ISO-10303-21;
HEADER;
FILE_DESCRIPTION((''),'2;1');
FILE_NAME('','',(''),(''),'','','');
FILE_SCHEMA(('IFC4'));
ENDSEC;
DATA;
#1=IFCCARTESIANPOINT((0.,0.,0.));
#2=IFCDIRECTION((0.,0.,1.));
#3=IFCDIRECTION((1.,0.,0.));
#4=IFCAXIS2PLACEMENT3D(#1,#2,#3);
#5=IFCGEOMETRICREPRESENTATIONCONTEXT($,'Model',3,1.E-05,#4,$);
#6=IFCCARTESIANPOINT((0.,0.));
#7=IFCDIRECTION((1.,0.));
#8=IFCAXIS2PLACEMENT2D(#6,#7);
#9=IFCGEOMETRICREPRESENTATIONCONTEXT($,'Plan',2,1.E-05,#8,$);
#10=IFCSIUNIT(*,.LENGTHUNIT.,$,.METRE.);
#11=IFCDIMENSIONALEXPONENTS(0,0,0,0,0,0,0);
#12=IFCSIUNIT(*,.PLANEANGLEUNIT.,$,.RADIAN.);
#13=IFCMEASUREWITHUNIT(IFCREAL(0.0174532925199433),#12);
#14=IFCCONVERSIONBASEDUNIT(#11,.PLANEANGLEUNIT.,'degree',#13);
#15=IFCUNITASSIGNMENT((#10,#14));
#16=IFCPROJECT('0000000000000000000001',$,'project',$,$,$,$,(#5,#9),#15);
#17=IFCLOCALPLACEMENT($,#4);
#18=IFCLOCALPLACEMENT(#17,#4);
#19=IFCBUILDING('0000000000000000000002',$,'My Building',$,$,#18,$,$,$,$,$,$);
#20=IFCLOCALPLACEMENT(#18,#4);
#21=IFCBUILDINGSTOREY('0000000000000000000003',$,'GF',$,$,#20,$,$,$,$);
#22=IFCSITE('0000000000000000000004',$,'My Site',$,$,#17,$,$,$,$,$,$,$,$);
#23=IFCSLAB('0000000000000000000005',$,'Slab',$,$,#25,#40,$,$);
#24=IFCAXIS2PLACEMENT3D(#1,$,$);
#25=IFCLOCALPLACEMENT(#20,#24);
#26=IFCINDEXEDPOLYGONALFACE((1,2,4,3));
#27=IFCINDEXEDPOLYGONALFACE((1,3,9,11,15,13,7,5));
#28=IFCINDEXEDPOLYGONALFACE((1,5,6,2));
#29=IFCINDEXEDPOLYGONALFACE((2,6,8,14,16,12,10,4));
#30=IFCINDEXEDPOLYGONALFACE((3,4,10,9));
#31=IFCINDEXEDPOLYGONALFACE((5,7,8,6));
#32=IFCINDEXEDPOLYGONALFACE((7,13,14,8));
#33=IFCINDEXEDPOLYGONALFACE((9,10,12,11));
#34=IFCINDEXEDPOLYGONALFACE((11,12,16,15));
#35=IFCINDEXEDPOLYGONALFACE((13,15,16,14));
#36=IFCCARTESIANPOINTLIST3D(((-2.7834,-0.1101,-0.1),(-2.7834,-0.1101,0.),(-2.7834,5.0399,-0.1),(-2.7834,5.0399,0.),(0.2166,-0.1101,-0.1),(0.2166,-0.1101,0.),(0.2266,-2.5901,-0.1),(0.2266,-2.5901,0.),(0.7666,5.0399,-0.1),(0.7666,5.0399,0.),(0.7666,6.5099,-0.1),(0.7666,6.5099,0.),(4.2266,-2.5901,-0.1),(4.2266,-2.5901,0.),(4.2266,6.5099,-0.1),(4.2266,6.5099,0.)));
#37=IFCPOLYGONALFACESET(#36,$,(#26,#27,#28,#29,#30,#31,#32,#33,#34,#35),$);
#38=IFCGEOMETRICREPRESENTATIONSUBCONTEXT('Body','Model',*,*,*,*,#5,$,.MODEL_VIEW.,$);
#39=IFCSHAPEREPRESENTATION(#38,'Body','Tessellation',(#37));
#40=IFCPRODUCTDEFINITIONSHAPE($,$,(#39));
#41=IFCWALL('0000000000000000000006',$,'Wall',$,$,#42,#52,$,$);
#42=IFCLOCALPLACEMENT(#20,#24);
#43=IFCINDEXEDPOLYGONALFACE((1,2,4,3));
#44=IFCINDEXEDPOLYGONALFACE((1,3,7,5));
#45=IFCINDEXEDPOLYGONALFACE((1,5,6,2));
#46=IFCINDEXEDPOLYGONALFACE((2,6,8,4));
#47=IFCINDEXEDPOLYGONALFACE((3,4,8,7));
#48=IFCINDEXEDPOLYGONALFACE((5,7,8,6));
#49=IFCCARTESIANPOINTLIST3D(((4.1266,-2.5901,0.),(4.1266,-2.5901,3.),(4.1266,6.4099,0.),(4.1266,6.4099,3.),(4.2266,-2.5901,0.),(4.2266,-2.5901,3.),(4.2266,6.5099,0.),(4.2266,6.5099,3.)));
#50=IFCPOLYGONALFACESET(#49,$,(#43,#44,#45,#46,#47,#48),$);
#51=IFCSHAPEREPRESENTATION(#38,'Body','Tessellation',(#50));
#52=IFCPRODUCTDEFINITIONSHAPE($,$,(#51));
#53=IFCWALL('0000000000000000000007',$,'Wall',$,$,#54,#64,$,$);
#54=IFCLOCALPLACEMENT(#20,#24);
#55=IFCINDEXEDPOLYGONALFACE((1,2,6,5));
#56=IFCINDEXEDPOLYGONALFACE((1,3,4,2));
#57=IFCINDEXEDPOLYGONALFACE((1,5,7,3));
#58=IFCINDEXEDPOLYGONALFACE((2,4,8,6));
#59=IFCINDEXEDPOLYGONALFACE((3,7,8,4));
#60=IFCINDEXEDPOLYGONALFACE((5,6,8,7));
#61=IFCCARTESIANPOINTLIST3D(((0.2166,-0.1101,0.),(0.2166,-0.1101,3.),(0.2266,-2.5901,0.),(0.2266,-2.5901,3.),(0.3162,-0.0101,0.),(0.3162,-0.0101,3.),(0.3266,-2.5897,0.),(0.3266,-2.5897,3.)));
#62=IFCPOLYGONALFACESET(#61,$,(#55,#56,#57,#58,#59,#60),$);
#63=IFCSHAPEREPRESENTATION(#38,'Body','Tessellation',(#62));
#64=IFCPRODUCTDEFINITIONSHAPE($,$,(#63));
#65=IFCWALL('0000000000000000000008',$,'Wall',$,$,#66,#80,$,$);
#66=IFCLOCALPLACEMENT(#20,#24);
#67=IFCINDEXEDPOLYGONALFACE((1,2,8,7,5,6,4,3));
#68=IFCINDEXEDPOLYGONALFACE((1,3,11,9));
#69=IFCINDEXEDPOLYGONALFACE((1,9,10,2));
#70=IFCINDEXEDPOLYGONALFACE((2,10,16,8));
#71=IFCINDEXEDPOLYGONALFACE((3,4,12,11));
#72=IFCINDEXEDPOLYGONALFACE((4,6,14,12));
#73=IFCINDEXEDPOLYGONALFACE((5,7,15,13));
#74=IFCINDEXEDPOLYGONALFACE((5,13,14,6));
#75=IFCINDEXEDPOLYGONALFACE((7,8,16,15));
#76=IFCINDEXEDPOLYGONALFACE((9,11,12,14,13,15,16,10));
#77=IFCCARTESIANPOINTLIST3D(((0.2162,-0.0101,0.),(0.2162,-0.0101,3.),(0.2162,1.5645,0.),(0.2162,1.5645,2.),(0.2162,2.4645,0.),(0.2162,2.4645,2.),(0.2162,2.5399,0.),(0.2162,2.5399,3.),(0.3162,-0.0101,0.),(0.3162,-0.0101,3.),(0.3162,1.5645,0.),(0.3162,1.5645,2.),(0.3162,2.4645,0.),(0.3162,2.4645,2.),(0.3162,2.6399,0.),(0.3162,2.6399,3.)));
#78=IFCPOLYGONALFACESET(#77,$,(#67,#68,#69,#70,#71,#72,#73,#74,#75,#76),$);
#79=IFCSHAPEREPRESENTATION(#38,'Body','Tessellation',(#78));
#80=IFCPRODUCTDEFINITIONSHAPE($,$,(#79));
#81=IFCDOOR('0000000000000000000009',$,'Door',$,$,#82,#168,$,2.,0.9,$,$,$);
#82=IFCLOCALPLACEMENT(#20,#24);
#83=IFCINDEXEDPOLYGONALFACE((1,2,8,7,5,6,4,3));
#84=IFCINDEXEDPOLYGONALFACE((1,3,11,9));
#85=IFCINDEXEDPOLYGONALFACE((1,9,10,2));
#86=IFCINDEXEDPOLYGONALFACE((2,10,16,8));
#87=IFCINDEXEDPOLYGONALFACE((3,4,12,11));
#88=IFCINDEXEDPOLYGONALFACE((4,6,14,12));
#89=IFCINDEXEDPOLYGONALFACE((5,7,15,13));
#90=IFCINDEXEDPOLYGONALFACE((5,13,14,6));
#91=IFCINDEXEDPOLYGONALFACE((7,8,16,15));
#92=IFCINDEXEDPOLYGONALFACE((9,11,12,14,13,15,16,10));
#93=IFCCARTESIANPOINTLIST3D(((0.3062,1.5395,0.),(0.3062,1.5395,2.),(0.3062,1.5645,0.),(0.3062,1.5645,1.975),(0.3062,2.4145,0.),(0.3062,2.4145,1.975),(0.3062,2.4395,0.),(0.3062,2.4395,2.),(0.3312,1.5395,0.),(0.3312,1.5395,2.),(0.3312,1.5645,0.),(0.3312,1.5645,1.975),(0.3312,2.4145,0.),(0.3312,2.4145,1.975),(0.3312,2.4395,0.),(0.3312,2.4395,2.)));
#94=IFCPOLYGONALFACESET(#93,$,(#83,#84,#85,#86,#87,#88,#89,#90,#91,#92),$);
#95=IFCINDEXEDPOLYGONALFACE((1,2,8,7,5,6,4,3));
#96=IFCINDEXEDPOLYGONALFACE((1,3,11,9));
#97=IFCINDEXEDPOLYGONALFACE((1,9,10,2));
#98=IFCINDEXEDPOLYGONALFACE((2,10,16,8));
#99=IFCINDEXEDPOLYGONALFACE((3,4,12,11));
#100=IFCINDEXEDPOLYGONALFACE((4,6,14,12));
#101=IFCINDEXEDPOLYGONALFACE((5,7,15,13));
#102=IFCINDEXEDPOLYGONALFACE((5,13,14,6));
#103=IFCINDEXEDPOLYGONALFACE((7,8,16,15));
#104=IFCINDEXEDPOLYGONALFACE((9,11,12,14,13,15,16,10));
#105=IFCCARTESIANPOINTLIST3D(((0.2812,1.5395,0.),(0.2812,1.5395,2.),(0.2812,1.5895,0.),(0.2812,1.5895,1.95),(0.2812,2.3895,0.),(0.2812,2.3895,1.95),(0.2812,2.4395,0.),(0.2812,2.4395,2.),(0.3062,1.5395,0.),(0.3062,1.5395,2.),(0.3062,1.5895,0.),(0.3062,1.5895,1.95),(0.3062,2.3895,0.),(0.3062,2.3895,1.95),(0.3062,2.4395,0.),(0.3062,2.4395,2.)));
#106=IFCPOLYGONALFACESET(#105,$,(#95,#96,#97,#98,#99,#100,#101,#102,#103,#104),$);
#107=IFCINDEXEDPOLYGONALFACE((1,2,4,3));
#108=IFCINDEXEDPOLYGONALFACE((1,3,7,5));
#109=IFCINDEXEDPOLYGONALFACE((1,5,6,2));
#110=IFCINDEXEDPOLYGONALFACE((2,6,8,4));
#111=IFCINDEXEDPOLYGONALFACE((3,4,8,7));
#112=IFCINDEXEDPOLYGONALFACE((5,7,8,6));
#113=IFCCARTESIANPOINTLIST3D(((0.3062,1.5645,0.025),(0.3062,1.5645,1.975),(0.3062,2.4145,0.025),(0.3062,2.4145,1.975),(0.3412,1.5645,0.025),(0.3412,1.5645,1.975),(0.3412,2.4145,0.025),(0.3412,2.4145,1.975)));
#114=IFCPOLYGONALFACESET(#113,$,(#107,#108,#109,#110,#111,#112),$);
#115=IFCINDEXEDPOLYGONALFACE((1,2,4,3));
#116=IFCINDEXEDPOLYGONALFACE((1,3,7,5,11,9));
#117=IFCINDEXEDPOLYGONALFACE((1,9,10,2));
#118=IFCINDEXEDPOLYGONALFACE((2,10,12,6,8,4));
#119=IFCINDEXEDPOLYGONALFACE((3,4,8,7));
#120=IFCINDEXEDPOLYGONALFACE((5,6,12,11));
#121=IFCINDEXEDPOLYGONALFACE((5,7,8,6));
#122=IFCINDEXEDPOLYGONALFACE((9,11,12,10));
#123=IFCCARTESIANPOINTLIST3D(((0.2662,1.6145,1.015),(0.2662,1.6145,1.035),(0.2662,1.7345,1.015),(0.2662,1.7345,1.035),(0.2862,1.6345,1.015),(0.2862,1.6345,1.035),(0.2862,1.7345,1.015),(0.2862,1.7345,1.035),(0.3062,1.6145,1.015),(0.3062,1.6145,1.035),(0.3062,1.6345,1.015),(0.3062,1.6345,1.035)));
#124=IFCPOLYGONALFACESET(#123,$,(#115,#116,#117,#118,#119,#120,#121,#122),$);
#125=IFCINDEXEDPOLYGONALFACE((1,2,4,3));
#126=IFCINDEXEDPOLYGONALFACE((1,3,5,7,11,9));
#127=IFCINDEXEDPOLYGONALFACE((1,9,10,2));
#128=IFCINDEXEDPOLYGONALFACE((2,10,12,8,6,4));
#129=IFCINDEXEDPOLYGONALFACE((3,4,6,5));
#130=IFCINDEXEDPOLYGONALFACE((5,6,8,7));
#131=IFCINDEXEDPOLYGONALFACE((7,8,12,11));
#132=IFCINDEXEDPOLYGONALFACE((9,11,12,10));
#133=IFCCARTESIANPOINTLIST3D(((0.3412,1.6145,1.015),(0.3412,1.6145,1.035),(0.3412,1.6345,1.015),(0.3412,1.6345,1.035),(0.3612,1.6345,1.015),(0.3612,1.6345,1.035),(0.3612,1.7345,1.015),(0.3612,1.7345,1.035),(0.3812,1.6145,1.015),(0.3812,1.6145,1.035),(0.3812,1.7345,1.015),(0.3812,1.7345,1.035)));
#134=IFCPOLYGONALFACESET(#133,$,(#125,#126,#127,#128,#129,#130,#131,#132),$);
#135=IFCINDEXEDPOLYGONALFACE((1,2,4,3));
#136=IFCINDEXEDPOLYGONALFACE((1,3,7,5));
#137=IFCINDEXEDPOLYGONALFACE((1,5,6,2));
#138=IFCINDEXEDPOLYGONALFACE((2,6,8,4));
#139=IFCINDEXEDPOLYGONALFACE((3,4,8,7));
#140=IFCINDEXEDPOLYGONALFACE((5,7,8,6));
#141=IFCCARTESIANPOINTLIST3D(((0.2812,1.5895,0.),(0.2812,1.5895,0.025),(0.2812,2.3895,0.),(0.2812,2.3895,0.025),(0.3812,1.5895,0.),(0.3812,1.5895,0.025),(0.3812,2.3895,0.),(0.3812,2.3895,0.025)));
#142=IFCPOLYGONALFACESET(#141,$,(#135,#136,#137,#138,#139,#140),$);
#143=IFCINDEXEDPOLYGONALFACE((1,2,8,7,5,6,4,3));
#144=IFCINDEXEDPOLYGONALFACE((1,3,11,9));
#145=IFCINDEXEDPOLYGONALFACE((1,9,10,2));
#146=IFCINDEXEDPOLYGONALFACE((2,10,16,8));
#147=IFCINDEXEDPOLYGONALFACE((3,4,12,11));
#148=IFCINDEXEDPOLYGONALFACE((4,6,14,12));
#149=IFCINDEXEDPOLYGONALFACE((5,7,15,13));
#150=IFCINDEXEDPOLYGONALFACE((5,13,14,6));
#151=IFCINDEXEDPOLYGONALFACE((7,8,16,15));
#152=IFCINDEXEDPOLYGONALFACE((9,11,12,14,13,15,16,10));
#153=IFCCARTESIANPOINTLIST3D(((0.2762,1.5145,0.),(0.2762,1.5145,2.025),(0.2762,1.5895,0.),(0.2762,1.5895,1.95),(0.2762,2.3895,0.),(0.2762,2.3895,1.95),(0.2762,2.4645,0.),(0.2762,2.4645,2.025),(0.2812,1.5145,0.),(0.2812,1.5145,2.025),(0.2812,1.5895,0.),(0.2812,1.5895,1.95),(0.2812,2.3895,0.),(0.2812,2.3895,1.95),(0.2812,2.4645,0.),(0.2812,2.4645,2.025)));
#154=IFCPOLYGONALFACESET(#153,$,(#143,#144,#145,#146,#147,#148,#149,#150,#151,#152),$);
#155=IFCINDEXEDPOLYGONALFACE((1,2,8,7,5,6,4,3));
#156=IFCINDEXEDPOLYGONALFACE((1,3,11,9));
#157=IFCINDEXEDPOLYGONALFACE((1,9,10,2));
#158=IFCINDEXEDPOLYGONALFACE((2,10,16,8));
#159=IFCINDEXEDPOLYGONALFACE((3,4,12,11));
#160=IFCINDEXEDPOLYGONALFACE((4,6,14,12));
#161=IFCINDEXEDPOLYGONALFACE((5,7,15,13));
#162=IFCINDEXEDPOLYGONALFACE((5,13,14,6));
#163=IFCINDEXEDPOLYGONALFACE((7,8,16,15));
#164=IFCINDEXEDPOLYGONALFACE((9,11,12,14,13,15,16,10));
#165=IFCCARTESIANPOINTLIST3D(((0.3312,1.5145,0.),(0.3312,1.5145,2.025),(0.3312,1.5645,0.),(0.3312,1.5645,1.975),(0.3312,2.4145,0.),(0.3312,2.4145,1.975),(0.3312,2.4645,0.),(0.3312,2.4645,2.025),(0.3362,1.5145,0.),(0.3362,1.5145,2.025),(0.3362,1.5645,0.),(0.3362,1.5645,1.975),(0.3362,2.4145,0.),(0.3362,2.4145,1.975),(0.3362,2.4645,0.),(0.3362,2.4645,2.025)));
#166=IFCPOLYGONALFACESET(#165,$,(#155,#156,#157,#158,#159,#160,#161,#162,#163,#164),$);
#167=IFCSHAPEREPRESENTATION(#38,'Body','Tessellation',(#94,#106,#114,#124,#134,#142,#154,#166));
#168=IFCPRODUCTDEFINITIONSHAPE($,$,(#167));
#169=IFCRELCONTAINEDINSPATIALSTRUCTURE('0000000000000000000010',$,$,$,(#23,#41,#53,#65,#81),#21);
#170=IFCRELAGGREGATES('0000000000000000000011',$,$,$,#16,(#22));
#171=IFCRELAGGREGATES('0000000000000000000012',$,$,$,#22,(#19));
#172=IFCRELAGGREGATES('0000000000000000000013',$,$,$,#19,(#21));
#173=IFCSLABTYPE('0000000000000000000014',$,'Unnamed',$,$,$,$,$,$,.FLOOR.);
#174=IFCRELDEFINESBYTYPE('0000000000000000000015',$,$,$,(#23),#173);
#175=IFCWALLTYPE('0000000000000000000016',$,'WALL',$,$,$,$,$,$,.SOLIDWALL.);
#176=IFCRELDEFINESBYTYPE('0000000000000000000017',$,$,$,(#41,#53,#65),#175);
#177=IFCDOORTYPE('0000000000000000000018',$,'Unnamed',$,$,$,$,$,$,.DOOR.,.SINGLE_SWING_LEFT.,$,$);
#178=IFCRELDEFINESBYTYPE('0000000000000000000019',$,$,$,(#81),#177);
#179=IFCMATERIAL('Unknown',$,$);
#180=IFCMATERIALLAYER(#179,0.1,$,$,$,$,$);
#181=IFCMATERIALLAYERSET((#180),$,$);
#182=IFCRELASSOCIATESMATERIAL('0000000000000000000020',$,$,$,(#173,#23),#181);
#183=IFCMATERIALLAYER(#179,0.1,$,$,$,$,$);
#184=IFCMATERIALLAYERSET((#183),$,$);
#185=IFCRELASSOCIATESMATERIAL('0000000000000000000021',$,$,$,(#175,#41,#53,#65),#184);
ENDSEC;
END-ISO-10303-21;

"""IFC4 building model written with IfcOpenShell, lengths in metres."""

from ifc_helpers import new_model, entity, si_unit, converted_unit, frame, origin_with_axes, origin_2d_with_axis, place, context, subcontext, project, spatial, line, indexed_curve, outline, extrude, shape, source, transform, mapped, material, layer, layer_set, layer_usage, type_object, type_shapes, element, fill, save


model = new_model("IFC4")

# Units and contexts
model_context = context("Model", 3, precision=1e-05, world=origin_with_axes())
plan_context = context("Plan", 2, precision=1e-05, world=origin_2d_with_axis())
body_context_1 = subcontext(model_context, "Body", "Model", "MODEL_VIEW")
body_context_2 = subcontext(plan_context, "Body", "Plan", "PLAN_VIEW")
ifc_project = project(units=[si_unit("LENGTHUNIT", "METRE"), converted_unit("PLANEANGLEUNIT", "degree", entity("IfcReal", 0.0174532925199433), si_unit("PLANEANGLEUNIT", "RADIAN"), dimensions=[0, 0, 0, 0, 0, 0, 0])], contexts=[model_context, plan_context])

# Site, building, storey
site_placement = place(None, origin_with_axes())
site = spatial("IfcSite", under=ifc_project, at=site_placement, Name="My Site")
building_placement = place(site_placement, origin_with_axes())
building = spatial("IfcBuilding", under=site, at=building_placement, Name="My Building")
storey_placement = place(building_placement, origin_with_axes())
storey = spatial("IfcBuildingStorey", under=building, at=storey_placement, Name="GF")

# Slab
ifc_material = material(Name="Unknown")
ifc_layer_1 = layer(ifc_material, 0.1)
ifc_layer_set_1 = layer_set([ifc_layer_1])
ifc_layer_usage_1 = layer_usage(ifc_layer_set_1, "AXIS3", "POSITIVE", -0.1)
slab_type_1 = type_object("IfcSlabType", Name="Unnamed", PredefinedType="FLOOR", material=ifc_layer_set_1)
slab_1_placement = place(storey_placement, frame((4.2266, -2.5901, 0.0), z_axis=(0.0, 0.0, 1.0), x_axis=(1.0, 0.0, 0.0)))
element("IfcSlab", 1, at=slab_1_placement, inside=storey, type_object=slab_type_1, material=ifc_layer_usage_1, Name="Slab", context=body_context_1, shape_type="SweptSolid", body=[
    extrude(outline(indexed_curve([(0.0, 0.0), (0.0, 9.1), (-3.46, 9.1), (-3.46, 7.63), (-7.01, 7.63), (-7.01, 2.48), (-4.01, 2.48), (-4.0, 0.0), (0.0, 0.0)])), frame((0.0, 0.0, -0.1), z_axis=(0.0, 0.0, 1.0), x_axis=(1.0, 0.0, 0.0)), (0.0, 0.0, 1.0), 0.1),
])

# Shared definitions
ifc_layer_2 = layer(ifc_material, 0.1)
ifc_layer_set_2 = layer_set([ifc_layer_2])
wall_type = type_object("IfcWallType", Name="WALL", PredefinedType="SOLIDWALL", material=ifc_layer_set_2)
shared_shape_1 = source(origin_with_axes(), body_context_1, "Body", "SweptSolid", [
    extrude(outline(indexed_curve([(0.0, 0.0), (0.9, 0.0), (0.9, 2.0), (0.0, 2.0)], segments=[line(1, 2, 3, 4, 1)])), frame((0.0, -0.6, 0.0), z_axis=(0.0, -1.0, 0.0), x_axis=(1.0, 0.0, 0.0)), (0.0, 0.0, -1.0), 1.2),
])
door_type = type_object("IfcDoorType", Name="Unnamed", OperationType="SINGLE_SWING_LEFT", PredefinedType="DOOR")
shared_shape_2 = source(origin_with_axes(), body_context_1, "Body", "SweptSolid", [
    extrude(outline(indexed_curve([(0.0, 0.0), (0.0, 2.0), (0.9, 2.0), (0.9, 0.0), (0.875, 0.0), (0.875, 1.975), (0.025, 1.975), (0.025, 0.0)], segments=[line(1, 2, 3, 4, 5, 6, 7, 8, 1)])), frame((0.0, 0.025, 0.0), z_axis=(0.0, -1.0, 0.0), x_axis=(1.0, 0.0, 0.0)), (0.0, 0.0, -1.0), 0.025),
    extrude(outline(indexed_curve([(0.0, 0.0), (0.0, 2.0), (0.9, 2.0), (0.9, 0.0), (0.85, 0.0), (0.85, 1.95), (0.05, 1.95), (0.05, 0.0)], segments=[line(1, 2, 3, 4, 5, 6, 7, 8, 1)])), frame((0.0, 0.0, 0.0), z_axis=(0.0, -1.0, 0.0), x_axis=(1.0, 0.0, 0.0)), (0.0, 0.0, -1.0), 0.025),
    extrude(outline(indexed_curve([(0.0, 0.0), (0.85, 0.0), (0.85, 0.035), (0.0, 0.035)], segments=[line(1, 2, 3, 4, 1)])), frame((0.025, 0.025, 0.025), z_axis=(0.0, 0.0, 1.0), x_axis=(1.0, 0.0, 0.0)), (0.0, 0.0, 1.0), 1.95),
    extrude(outline(indexed_curve([(0.0, 0.0), (0.0, -0.04), (-0.12, -0.04), (-0.12, -0.02), (-0.02, -0.02), (-0.02, 0.0)], segments=[line(1, 2, 3, 4, 5, 6, 1)])), frame((0.825, 0.025, 1.015), z_axis=(0.0, 0.0, 1.0), x_axis=(1.0, 0.0, 0.0)), (0.0, 0.0, 1.0), 0.02),
    extrude(outline(indexed_curve([(0.0, 0.0), (0.0, 0.04), (-0.12, 0.04), (-0.12, 0.02), (-0.02, 0.02), (-0.02, 0.0)], segments=[line(1, 2, 3, 4, 5, 6, 1)])), frame((0.825, 0.06, 1.015), z_axis=(0.0, 0.0, 1.0), x_axis=(1.0, 0.0, 0.0)), (0.0, 0.0, 1.0), 0.02),
    extrude(outline(indexed_curve([(0.0, 0.0), (0.8, 0.0), (0.8, 0.1), (0.0, 0.1)], segments=[line(1, 2, 3, 4, 1)])), frame((0.05, 0.0, 0.0), z_axis=(0.0, 0.0, 1.0), x_axis=(1.0, 0.0, 0.0)), (0.0, 0.0, 1.0), 0.025),
    extrude(outline(indexed_curve([(0.0, 0.0), (0.0, 2.025), (0.95, 2.025), (0.95, 0.0), (0.875, 0.0), (0.875, 1.95), (0.075, 1.95), (0.075, 0.0)], segments=[line(1, 2, 3, 4, 5, 6, 7, 8, 1)])), frame((-0.025, -0.005, 0.0), z_axis=(0.0, -1.0, 0.0), x_axis=(1.0, 0.0, 0.0)), (0.0, 0.0, -1.0), 0.005),
    extrude(outline(indexed_curve([(0.0, 0.0), (0.0, 2.025), (0.95, 2.025), (0.95, 0.0), (0.9, 0.0), (0.9, 1.975), (0.05, 1.975), (0.05, 0.0)], segments=[line(1, 2, 3, 4, 5, 6, 7, 8, 1)])), frame((-0.025, 0.05, 0.0), z_axis=(0.0, -1.0, 0.0), x_axis=(1.0, 0.0, 0.0)), (0.0, 0.0, -1.0), 0.005),
])
shared_shape_3 = source(origin_with_axes(), body_context_2, "Body", "Curve2D", [
    entity("IfcIndexedPolyCurve", entity("IfcCartesianPointList2D", [[0.0, 0.0], [0.0, 0.05], [0.025, 0.05], [0.025, 0.025], [0.05, 0.025], [0.05, 0.0]]), [entity("IfcLineIndex", [1, 2, 3, 4, 5, 6, 1])]),
    entity("IfcIndexedPolyCurve", entity("IfcCartesianPointList2D", [[0.9, 0.0], [0.9, 0.05], [0.875, 0.05], [0.875, 0.025], [0.85, 0.025], [0.85, 0.0]]), [entity("IfcLineIndex", [1, 2, 3, 4, 5, 6, 1])]),
    entity("IfcTrimmedCurve", entity("IfcEllipse", entity("IfcAxis2Placement2D", entity("IfcCartesianPoint", [0.06, 0.05]), entity("IfcDirection", [1.0, 0.0])), 0.815, 0.85), [entity("IfcCartesianPoint", [0.875, 0.05])], [entity("IfcCartesianPoint", [0.06, 0.9])], True, "CARTESIAN"),
    entity("IfcIndexedPolyCurve", entity("IfcCartesianPointList2D", [[0.025, 0.05], [0.06, 0.05], [0.06, 0.9], [0.025, 0.9]]), [entity("IfcLineIndex", [1, 2, 3, 4, 1])]),
])
type_shapes(door_type, [shared_shape_2, shared_shape_3])

# Wall
ifc_layer_usage_2 = layer_usage(ifc_layer_set_2, "AXIS2", "POSITIVE", 0.0)
wall_1_placement = place(storey_placement, frame((4.2266, -2.5901, 0.0), z_axis=(0.0, 0.0, 1.0), x_axis=(0.0, 1.0, 0.0)))
element("IfcWall", 2, at=wall_1_placement, inside=storey, type_object=wall_type, material=ifc_layer_usage_2, Name="Wall", context=body_context_1, shape_type="SweptSolid", body=[
    extrude(outline(indexed_curve([(0.0, 0.0), (0.0, 0.1), (9.0, 0.1), (9.1, 0.0)], segments=[line(1, 2, 3, 4, 1)])), origin_with_axes(), (0.0, 0.0, 1.0), 3.0),
])

# Wall
ifc_layer_usage_3 = layer_usage(ifc_layer_set_2, "AXIS2", "POSITIVE", 0.0)
wall_2_placement = place(storey_placement, frame((0.2166, -0.1101, 0.0), z_axis=(0.0, 0.0, 1.0), x_axis=(0.004032, -0.999992, 0.0)))
element("IfcWall", 3, at=wall_2_placement, inside=storey, type_object=wall_type, material=ifc_layer_usage_3, Name="Wall", context=body_context_1, shape_type="SweptSolid", body=[
    extrude(outline(indexed_curve([(0.0, 0.0), (-0.0996, 0.1), (2.48, 0.1), (2.48, 0.0)], segments=[line(1, 2, 3, 4, 1)])), origin_with_axes(), (0.0, 0.0, 1.0), 3.0),
])

# Wall, opening, door
ifc_layer_usage_4 = layer_usage(ifc_layer_set_2, "AXIS2", "POSITIVE", 0.0)
wall_3_placement = place(storey_placement, frame((0.3162, -0.0101, 0.0), z_axis=(0.0, 0.0, 1.0), x_axis=(0.0, 1.0, 0.0)))
wall_3 = element("IfcWall", 4, at=wall_3_placement, inside=storey, type_object=wall_type, material=ifc_layer_usage_4, Name="Wall", context=body_context_1, shape_type="SweptSolid", body=[
    extrude(outline(indexed_curve([(0.0, 0.0), (0.0, 0.1), (2.55, 0.1), (2.65, 0.0)], segments=[line(1, 2, 3, 4, 1)])), origin_with_axes(), (0.0, 0.0, 1.0), 3.0),
])
opening_1_placement = place(wall_3_placement, frame((1.5746, 0.0, 0.0), z_axis=(0.0, 0.0, 1.0), x_axis=(1.0, 0.0, 0.0)))
opening_1 = element("IfcOpeningElement", 5, at=opening_1_placement, cuts=wall_3, PredefinedType="OPENING", context=body_context_1, shape_type="MappedRepresentation", body=[
    mapped(shared_shape_1, transform((0.0, 0.0, 0.0), x_axis=(1.0, 0.0, 0.0), y_axis=(0.0, 1.0, 0.0), z_axis=(0.0, 0.0, 1.0), scale=1.0)),
])
door_1_placement = place(opening_1_placement, frame((0.875, 0.035, 0.0), z_axis=(0.0, 0.0, 1.0), x_axis=(-1.0, 0.0, 0.0)))
door_1 = element("IfcDoor", 6, at=door_1_placement, inside=storey, type_object=door_type, Name="Door", OverallHeight=2.0, OverallWidth=0.9, shapes=[
    shape(body_context_1, "Body", "MappedRepresentation", [mapped(shared_shape_2, transform((0.0, 0.0, 0.0), x_axis=(1.0, 0.0, 0.0), y_axis=(0.0, 1.0, 0.0), z_axis=(0.0, 0.0, 1.0), scale=1.0))]),
    shape(body_context_2, "Body", "MappedRepresentation", [mapped(shared_shape_3, transform((0.0, 0.0, 0.0), x_axis=(1.0, 0.0, 0.0), y_axis=(0.0, 1.0, 0.0), z_axis=(0.0, 0.0, 1.0), scale=1.0))]),
])
fill(opening_1, door_1)

save(model, "model.ifc")
